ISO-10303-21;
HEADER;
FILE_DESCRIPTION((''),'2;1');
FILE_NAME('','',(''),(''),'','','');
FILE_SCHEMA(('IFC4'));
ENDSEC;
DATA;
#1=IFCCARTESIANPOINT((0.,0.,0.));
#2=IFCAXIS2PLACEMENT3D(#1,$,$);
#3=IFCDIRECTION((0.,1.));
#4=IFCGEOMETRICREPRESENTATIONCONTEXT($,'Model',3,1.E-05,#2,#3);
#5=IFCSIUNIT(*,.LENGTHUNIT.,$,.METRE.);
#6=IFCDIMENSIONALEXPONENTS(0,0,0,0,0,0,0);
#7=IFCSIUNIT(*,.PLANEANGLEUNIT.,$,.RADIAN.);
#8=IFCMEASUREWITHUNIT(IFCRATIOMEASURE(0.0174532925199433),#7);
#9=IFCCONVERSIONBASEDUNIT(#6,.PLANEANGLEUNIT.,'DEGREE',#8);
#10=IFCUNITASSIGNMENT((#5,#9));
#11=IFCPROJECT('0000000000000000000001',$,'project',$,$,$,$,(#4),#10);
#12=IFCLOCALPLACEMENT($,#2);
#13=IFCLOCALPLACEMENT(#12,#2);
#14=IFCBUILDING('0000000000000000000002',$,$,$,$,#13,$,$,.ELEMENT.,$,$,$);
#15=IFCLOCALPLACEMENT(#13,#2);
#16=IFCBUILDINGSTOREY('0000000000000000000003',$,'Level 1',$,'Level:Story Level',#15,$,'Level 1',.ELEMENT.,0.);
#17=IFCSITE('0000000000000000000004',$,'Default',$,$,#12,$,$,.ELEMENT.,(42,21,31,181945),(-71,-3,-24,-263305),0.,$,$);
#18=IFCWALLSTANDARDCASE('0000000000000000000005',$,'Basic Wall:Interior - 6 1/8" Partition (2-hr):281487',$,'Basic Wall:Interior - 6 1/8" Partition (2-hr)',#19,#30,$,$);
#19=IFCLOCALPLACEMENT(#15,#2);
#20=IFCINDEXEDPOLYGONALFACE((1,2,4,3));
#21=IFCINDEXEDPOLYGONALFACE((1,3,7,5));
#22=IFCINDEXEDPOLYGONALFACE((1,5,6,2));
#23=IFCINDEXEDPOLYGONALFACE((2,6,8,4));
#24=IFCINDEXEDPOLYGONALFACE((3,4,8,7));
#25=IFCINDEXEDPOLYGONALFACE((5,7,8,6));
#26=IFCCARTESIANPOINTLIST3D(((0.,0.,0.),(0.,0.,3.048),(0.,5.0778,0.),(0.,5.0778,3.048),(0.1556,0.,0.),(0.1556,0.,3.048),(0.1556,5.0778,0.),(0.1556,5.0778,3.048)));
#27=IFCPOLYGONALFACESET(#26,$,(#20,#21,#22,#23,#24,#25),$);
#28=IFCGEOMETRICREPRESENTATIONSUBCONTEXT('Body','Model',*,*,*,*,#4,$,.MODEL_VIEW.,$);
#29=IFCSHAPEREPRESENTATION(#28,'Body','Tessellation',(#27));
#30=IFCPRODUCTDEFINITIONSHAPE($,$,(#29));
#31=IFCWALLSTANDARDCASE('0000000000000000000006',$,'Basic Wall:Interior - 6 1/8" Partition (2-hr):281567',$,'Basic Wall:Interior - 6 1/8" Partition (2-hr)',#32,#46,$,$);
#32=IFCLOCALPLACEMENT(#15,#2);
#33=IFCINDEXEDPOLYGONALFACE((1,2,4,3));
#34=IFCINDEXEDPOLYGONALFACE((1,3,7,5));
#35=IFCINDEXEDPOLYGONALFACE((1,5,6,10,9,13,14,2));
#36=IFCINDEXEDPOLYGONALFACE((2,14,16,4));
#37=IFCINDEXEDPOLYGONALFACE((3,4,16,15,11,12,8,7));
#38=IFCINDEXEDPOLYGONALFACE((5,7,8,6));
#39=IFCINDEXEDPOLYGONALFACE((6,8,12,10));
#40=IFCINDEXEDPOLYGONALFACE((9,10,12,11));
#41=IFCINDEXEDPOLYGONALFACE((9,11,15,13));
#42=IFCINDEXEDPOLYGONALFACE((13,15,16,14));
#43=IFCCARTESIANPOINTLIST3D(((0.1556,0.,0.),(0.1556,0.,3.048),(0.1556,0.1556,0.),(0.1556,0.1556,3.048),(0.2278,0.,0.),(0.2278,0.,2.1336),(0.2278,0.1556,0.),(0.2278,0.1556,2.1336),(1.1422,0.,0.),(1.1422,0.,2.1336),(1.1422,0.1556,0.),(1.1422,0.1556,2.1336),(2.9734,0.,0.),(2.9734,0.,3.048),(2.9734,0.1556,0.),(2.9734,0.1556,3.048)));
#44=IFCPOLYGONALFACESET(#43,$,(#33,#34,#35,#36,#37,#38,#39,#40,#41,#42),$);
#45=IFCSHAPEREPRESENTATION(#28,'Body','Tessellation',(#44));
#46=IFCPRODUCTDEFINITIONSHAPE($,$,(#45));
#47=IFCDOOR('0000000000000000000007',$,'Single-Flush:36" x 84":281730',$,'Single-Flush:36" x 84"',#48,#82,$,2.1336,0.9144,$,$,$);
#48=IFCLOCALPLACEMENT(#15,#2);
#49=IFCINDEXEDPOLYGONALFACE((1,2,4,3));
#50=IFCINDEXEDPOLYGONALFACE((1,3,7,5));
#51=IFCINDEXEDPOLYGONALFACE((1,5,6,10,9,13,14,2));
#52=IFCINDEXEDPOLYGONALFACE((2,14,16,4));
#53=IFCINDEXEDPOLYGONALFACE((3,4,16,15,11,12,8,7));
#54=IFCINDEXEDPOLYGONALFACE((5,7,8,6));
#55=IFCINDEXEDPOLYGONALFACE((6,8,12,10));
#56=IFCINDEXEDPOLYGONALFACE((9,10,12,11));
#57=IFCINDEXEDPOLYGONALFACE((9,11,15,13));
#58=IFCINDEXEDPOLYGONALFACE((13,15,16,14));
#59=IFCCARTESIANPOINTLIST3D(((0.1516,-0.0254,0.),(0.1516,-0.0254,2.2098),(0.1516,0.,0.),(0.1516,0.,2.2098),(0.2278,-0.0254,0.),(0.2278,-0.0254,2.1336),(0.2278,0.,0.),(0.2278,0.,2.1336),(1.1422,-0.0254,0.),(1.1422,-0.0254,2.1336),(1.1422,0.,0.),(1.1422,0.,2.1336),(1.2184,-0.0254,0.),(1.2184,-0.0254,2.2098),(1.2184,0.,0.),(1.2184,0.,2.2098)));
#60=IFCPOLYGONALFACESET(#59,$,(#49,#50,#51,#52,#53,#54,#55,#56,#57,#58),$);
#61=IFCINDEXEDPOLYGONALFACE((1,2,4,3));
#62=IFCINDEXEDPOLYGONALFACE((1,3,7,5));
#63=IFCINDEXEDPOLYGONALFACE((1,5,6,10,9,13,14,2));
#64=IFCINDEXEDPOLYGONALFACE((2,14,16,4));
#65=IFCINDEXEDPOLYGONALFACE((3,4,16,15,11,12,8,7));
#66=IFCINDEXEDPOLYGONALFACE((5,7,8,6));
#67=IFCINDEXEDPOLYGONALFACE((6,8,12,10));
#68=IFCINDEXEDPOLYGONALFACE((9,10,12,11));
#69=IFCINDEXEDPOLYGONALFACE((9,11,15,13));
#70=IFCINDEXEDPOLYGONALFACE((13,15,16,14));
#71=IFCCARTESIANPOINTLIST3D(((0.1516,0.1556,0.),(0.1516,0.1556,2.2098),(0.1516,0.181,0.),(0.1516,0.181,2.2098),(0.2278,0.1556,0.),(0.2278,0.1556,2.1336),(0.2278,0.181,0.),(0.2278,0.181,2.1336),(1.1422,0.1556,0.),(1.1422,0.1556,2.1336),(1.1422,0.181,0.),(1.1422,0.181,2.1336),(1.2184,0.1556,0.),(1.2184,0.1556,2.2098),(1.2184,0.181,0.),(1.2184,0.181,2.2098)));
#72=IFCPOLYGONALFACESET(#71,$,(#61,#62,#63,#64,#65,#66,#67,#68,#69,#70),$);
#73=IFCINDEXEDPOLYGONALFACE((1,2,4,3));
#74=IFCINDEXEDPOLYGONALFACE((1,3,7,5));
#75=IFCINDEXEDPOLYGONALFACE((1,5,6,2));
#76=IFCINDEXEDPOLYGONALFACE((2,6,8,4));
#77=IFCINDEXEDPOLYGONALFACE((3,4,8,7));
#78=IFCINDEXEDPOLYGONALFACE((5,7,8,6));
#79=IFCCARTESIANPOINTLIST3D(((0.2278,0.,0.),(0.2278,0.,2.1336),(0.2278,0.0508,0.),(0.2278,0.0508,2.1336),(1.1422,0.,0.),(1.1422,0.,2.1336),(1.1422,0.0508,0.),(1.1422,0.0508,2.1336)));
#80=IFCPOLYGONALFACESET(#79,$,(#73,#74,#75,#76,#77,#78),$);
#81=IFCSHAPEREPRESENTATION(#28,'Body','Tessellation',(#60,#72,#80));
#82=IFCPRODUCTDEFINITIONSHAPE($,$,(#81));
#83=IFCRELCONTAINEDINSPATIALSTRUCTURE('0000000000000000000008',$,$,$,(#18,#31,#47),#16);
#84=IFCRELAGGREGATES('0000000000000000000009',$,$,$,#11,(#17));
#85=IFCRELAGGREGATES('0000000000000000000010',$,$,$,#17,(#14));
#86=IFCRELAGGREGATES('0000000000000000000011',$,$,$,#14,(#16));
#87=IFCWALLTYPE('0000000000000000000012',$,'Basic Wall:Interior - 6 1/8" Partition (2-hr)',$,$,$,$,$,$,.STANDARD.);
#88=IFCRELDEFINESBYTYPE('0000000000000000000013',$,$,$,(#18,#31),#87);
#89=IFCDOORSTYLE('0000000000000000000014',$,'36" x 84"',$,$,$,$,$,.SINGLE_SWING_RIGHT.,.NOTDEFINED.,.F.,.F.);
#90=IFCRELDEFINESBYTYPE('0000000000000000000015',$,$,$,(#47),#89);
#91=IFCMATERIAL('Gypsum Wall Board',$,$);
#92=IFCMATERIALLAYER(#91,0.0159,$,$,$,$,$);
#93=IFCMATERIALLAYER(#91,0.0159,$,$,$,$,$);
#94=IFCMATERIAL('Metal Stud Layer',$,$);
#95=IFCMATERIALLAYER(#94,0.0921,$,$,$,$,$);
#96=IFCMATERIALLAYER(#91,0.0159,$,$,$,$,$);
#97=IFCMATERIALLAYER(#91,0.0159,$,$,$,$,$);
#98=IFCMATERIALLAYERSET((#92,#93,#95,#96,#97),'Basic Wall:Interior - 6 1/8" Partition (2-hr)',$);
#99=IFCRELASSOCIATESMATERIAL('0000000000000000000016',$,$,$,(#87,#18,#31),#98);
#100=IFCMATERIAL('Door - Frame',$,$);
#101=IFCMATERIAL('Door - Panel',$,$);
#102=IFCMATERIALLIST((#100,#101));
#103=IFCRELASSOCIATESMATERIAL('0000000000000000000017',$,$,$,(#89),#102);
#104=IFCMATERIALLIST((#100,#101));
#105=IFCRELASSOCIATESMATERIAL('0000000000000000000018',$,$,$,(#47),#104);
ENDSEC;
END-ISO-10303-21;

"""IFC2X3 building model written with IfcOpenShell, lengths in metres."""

from ifc_helpers import new_model, entity, si_unit, converted_unit, direction, frame, frame_2d, origin, place, context, subcontext, project, spatial, polyline, rectangle, outline, extrude, source, transform, mapped, material, material_list, layer, layer_set, layer_usage, type_object, type_shapes, element, fill, save


model = new_model("IFC2X3")

# Units and contexts
model_context = context("Model", 3, precision=1e-05, world=origin(), true_north=direction((0.0, 1.0)))
body_context = subcontext(model_context, "Body", "Model", "MODEL_VIEW")
ifc_project = project(units=[si_unit("LENGTHUNIT", "METRE"), converted_unit("PLANEANGLEUNIT", "DEGREE", entity("IfcRatioMeasure", 0.0174532925199433), si_unit("PLANEANGLEUNIT", "RADIAN"), dimensions=[0, 0, 0, 0, 0, 0, 0])], contexts=[model_context])

# Site, building, storey
site_placement = place(None, origin())
site = spatial("IfcSite", under=ifc_project, at=site_placement, Name="Default", CompositionType="ELEMENT", RefLatitude=(42, 21, 31, 181945), RefLongitude=(-71, -3, -24, -263305), RefElevation=0.0)
building_placement = place(site_placement, origin())
building = spatial("IfcBuilding", under=site, at=building_placement, CompositionType="ELEMENT")
storey_placement = place(building_placement, origin())
storey = spatial("IfcBuildingStorey", under=building, at=storey_placement, Name="Level 1", ObjectType="Level:Story Level", LongName="Level 1", CompositionType="ELEMENT", Elevation=0.0)

# Wall
ifc_material_1 = material(Name="Gypsum Wall Board")
ifc_layer_1 = layer(ifc_material_1, 0.0159)
ifc_layer_2 = layer(ifc_material_1, 0.0159)
ifc_material_2 = material(Name="Metal Stud Layer")
ifc_layer_3 = layer(ifc_material_2, 0.0921)
ifc_layer_4 = layer(ifc_material_1, 0.0159)
ifc_layer_5 = layer(ifc_material_1, 0.0159)
ifc_layer_set = layer_set([ifc_layer_1, ifc_layer_2, ifc_layer_3, ifc_layer_4, ifc_layer_5], Name="Basic Wall:Interior - 6 1/8\" Partition (2-hr)")
ifc_layer_usage_1 = layer_usage(ifc_layer_set, "AXIS2", "NEGATIVE", 0.0778)
wall_type = type_object("IfcWallType", Name="Basic Wall:Interior - 6 1/8\" Partition (2-hr)", PredefinedType="STANDARD", material=ifc_layer_set)
wall_1_placement = place(storey_placement, frame((0.0778, 5.0778, 0.0), z_axis=(0.0, 0.0, 1.0), x_axis=(0.0, -1.0, 0.0)))
element("IfcWallStandardCase", 1, at=wall_1_placement, inside=storey, type_object=wall_type, material=ifc_layer_usage_1, Name="Basic Wall:Interior - 6 1/8\" Partition (2-hr):281487", ObjectType="Basic Wall:Interior - 6 1/8\" Partition (2-hr)", context=body_context, shape_type="SweptSolid", body=[
    extrude(rectangle(XDim=5.0778, YDim=0.1556, at=frame_2d((2.5389, 0.0), x_axis=(-1.0, 0.0))), origin(), (0.0, 0.0, 1.0), 3.048),
])

# Wall, opening, door
ifc_layer_usage_2 = layer_usage(ifc_layer_set, "AXIS2", "NEGATIVE", 0.0778)
wall_2_placement = place(storey_placement, frame((0.1556, 0.0778, 0.0)))
wall_2 = element("IfcWallStandardCase", 2, at=wall_2_placement, inside=storey, type_object=wall_type, material=ifc_layer_usage_2, Name="Basic Wall:Interior - 6 1/8\" Partition (2-hr):281567", ObjectType="Basic Wall:Interior - 6 1/8\" Partition (2-hr)", context=body_context, shape_type="SweptSolid", body=[
    extrude(rectangle(XDim=2.8178, YDim=0.1556, at=frame_2d((1.4089, 0.0), x_axis=(-1.0, 0.0))), origin(), (0.0, 0.0, 1.0), 3.048),
])
opening_placement = place(wall_2_placement, frame((0.9866, 0.0778, 0.0)))
opening = element("IfcOpeningElement", 3, at=opening_placement, cuts=wall_2, ObjectType="Opening", context=body_context, shape_type="SweptSolid", body=[
    extrude(rectangle(XDim=0.9144, YDim=2.1336, at=frame_2d((1.0668, 0.4572), x_axis=(0.0, 1.0))), frame((0.0, 0.0, 0.0), z_axis=(0.0, -1.0, 0.0), x_axis=(0.0, 0.0, 1.0)), (0.0, 0.0, 1.0), 0.1556),
])
ifc_material_3 = material(Name="Door - Frame")
ifc_material_4 = material(Name="Door - Panel")
ifc_material_list_1 = material_list([ifc_material_3, ifc_material_4])
ifc_material_list_2 = material_list([ifc_material_3, ifc_material_4])
door_style = type_object("IfcDoorStyle", Name="36\" x 84\"", ConstructionType="NOTDEFINED", OperationType="SINGLE_SWING_RIGHT", ParameterTakesPrecedence=False, Sizeable=False, material=ifc_material_list_2)
shared_shape = source(origin(), body_context, "Body", "SweptSolid", [
    extrude(outline(polyline([(-0.5334, -1.124), (0.5334, -1.124), (0.5334, 1.0858), (0.4572, 1.0858), (0.4572, -1.0477), (-0.4572, -1.0477), (-0.4572, 1.0858), (-0.5334, 1.0858), (-0.5334, -1.124)])), frame((0.4572, 0.1556, 1.0858), z_axis=(0.0, 1.0, 0.0), x_axis=(1.0, 0.0, 0.0)), (0.0, 0.0, 1.0), 0.0254),
    extrude(outline(polyline([(-1.124, -0.5334), (1.0858, -0.5334), (1.0858, -0.4572), (-1.0477, -0.4572), (-1.0477, 0.4572), (1.0858, 0.4572), (1.0858, 0.5334), (-1.124, 0.5334), (-1.124, -0.5334)])), frame((0.4572, -0.0254, 1.0858), z_axis=(0.0, 1.0, 0.0), x_axis=(0.0, 0.0, -1.0)), (0.0, 0.0, 1.0), 0.0254),
    extrude(rectangle(XDim=0.0508, YDim=0.9144, at=frame_2d((0.0, 0.0), x_axis=(1.0, 0.0))), frame((0.4572, 0.1302, 0.0), z_axis=(0.0, 0.0, 1.0), x_axis=(0.0, 1.0, 0.0)), (0.0, 0.0, 1.0), 2.1336),
])
type_shapes(door_style, [shared_shape])
door_placement = place(opening_placement, frame((0.0, 0.0, 0.0), z_axis=(0.0, 0.0, 1.0), x_axis=(-1.0, 0.0, 0.0)))
door = element("IfcDoor", 4, at=door_placement, inside=storey, type_object=door_style, material=ifc_material_list_1, Name="Single-Flush:36\" x 84\":281730", ObjectType="Single-Flush:36\" x 84\"", OverallHeight=2.1336, OverallWidth=0.9144, context=body_context, shape_type="MappedRepresentation", body=[
    mapped(shared_shape, transform((0.0, 0.0, 0.0), scale=1.0)),
])
fill(opening, door)

save(model, "model.ifc")
